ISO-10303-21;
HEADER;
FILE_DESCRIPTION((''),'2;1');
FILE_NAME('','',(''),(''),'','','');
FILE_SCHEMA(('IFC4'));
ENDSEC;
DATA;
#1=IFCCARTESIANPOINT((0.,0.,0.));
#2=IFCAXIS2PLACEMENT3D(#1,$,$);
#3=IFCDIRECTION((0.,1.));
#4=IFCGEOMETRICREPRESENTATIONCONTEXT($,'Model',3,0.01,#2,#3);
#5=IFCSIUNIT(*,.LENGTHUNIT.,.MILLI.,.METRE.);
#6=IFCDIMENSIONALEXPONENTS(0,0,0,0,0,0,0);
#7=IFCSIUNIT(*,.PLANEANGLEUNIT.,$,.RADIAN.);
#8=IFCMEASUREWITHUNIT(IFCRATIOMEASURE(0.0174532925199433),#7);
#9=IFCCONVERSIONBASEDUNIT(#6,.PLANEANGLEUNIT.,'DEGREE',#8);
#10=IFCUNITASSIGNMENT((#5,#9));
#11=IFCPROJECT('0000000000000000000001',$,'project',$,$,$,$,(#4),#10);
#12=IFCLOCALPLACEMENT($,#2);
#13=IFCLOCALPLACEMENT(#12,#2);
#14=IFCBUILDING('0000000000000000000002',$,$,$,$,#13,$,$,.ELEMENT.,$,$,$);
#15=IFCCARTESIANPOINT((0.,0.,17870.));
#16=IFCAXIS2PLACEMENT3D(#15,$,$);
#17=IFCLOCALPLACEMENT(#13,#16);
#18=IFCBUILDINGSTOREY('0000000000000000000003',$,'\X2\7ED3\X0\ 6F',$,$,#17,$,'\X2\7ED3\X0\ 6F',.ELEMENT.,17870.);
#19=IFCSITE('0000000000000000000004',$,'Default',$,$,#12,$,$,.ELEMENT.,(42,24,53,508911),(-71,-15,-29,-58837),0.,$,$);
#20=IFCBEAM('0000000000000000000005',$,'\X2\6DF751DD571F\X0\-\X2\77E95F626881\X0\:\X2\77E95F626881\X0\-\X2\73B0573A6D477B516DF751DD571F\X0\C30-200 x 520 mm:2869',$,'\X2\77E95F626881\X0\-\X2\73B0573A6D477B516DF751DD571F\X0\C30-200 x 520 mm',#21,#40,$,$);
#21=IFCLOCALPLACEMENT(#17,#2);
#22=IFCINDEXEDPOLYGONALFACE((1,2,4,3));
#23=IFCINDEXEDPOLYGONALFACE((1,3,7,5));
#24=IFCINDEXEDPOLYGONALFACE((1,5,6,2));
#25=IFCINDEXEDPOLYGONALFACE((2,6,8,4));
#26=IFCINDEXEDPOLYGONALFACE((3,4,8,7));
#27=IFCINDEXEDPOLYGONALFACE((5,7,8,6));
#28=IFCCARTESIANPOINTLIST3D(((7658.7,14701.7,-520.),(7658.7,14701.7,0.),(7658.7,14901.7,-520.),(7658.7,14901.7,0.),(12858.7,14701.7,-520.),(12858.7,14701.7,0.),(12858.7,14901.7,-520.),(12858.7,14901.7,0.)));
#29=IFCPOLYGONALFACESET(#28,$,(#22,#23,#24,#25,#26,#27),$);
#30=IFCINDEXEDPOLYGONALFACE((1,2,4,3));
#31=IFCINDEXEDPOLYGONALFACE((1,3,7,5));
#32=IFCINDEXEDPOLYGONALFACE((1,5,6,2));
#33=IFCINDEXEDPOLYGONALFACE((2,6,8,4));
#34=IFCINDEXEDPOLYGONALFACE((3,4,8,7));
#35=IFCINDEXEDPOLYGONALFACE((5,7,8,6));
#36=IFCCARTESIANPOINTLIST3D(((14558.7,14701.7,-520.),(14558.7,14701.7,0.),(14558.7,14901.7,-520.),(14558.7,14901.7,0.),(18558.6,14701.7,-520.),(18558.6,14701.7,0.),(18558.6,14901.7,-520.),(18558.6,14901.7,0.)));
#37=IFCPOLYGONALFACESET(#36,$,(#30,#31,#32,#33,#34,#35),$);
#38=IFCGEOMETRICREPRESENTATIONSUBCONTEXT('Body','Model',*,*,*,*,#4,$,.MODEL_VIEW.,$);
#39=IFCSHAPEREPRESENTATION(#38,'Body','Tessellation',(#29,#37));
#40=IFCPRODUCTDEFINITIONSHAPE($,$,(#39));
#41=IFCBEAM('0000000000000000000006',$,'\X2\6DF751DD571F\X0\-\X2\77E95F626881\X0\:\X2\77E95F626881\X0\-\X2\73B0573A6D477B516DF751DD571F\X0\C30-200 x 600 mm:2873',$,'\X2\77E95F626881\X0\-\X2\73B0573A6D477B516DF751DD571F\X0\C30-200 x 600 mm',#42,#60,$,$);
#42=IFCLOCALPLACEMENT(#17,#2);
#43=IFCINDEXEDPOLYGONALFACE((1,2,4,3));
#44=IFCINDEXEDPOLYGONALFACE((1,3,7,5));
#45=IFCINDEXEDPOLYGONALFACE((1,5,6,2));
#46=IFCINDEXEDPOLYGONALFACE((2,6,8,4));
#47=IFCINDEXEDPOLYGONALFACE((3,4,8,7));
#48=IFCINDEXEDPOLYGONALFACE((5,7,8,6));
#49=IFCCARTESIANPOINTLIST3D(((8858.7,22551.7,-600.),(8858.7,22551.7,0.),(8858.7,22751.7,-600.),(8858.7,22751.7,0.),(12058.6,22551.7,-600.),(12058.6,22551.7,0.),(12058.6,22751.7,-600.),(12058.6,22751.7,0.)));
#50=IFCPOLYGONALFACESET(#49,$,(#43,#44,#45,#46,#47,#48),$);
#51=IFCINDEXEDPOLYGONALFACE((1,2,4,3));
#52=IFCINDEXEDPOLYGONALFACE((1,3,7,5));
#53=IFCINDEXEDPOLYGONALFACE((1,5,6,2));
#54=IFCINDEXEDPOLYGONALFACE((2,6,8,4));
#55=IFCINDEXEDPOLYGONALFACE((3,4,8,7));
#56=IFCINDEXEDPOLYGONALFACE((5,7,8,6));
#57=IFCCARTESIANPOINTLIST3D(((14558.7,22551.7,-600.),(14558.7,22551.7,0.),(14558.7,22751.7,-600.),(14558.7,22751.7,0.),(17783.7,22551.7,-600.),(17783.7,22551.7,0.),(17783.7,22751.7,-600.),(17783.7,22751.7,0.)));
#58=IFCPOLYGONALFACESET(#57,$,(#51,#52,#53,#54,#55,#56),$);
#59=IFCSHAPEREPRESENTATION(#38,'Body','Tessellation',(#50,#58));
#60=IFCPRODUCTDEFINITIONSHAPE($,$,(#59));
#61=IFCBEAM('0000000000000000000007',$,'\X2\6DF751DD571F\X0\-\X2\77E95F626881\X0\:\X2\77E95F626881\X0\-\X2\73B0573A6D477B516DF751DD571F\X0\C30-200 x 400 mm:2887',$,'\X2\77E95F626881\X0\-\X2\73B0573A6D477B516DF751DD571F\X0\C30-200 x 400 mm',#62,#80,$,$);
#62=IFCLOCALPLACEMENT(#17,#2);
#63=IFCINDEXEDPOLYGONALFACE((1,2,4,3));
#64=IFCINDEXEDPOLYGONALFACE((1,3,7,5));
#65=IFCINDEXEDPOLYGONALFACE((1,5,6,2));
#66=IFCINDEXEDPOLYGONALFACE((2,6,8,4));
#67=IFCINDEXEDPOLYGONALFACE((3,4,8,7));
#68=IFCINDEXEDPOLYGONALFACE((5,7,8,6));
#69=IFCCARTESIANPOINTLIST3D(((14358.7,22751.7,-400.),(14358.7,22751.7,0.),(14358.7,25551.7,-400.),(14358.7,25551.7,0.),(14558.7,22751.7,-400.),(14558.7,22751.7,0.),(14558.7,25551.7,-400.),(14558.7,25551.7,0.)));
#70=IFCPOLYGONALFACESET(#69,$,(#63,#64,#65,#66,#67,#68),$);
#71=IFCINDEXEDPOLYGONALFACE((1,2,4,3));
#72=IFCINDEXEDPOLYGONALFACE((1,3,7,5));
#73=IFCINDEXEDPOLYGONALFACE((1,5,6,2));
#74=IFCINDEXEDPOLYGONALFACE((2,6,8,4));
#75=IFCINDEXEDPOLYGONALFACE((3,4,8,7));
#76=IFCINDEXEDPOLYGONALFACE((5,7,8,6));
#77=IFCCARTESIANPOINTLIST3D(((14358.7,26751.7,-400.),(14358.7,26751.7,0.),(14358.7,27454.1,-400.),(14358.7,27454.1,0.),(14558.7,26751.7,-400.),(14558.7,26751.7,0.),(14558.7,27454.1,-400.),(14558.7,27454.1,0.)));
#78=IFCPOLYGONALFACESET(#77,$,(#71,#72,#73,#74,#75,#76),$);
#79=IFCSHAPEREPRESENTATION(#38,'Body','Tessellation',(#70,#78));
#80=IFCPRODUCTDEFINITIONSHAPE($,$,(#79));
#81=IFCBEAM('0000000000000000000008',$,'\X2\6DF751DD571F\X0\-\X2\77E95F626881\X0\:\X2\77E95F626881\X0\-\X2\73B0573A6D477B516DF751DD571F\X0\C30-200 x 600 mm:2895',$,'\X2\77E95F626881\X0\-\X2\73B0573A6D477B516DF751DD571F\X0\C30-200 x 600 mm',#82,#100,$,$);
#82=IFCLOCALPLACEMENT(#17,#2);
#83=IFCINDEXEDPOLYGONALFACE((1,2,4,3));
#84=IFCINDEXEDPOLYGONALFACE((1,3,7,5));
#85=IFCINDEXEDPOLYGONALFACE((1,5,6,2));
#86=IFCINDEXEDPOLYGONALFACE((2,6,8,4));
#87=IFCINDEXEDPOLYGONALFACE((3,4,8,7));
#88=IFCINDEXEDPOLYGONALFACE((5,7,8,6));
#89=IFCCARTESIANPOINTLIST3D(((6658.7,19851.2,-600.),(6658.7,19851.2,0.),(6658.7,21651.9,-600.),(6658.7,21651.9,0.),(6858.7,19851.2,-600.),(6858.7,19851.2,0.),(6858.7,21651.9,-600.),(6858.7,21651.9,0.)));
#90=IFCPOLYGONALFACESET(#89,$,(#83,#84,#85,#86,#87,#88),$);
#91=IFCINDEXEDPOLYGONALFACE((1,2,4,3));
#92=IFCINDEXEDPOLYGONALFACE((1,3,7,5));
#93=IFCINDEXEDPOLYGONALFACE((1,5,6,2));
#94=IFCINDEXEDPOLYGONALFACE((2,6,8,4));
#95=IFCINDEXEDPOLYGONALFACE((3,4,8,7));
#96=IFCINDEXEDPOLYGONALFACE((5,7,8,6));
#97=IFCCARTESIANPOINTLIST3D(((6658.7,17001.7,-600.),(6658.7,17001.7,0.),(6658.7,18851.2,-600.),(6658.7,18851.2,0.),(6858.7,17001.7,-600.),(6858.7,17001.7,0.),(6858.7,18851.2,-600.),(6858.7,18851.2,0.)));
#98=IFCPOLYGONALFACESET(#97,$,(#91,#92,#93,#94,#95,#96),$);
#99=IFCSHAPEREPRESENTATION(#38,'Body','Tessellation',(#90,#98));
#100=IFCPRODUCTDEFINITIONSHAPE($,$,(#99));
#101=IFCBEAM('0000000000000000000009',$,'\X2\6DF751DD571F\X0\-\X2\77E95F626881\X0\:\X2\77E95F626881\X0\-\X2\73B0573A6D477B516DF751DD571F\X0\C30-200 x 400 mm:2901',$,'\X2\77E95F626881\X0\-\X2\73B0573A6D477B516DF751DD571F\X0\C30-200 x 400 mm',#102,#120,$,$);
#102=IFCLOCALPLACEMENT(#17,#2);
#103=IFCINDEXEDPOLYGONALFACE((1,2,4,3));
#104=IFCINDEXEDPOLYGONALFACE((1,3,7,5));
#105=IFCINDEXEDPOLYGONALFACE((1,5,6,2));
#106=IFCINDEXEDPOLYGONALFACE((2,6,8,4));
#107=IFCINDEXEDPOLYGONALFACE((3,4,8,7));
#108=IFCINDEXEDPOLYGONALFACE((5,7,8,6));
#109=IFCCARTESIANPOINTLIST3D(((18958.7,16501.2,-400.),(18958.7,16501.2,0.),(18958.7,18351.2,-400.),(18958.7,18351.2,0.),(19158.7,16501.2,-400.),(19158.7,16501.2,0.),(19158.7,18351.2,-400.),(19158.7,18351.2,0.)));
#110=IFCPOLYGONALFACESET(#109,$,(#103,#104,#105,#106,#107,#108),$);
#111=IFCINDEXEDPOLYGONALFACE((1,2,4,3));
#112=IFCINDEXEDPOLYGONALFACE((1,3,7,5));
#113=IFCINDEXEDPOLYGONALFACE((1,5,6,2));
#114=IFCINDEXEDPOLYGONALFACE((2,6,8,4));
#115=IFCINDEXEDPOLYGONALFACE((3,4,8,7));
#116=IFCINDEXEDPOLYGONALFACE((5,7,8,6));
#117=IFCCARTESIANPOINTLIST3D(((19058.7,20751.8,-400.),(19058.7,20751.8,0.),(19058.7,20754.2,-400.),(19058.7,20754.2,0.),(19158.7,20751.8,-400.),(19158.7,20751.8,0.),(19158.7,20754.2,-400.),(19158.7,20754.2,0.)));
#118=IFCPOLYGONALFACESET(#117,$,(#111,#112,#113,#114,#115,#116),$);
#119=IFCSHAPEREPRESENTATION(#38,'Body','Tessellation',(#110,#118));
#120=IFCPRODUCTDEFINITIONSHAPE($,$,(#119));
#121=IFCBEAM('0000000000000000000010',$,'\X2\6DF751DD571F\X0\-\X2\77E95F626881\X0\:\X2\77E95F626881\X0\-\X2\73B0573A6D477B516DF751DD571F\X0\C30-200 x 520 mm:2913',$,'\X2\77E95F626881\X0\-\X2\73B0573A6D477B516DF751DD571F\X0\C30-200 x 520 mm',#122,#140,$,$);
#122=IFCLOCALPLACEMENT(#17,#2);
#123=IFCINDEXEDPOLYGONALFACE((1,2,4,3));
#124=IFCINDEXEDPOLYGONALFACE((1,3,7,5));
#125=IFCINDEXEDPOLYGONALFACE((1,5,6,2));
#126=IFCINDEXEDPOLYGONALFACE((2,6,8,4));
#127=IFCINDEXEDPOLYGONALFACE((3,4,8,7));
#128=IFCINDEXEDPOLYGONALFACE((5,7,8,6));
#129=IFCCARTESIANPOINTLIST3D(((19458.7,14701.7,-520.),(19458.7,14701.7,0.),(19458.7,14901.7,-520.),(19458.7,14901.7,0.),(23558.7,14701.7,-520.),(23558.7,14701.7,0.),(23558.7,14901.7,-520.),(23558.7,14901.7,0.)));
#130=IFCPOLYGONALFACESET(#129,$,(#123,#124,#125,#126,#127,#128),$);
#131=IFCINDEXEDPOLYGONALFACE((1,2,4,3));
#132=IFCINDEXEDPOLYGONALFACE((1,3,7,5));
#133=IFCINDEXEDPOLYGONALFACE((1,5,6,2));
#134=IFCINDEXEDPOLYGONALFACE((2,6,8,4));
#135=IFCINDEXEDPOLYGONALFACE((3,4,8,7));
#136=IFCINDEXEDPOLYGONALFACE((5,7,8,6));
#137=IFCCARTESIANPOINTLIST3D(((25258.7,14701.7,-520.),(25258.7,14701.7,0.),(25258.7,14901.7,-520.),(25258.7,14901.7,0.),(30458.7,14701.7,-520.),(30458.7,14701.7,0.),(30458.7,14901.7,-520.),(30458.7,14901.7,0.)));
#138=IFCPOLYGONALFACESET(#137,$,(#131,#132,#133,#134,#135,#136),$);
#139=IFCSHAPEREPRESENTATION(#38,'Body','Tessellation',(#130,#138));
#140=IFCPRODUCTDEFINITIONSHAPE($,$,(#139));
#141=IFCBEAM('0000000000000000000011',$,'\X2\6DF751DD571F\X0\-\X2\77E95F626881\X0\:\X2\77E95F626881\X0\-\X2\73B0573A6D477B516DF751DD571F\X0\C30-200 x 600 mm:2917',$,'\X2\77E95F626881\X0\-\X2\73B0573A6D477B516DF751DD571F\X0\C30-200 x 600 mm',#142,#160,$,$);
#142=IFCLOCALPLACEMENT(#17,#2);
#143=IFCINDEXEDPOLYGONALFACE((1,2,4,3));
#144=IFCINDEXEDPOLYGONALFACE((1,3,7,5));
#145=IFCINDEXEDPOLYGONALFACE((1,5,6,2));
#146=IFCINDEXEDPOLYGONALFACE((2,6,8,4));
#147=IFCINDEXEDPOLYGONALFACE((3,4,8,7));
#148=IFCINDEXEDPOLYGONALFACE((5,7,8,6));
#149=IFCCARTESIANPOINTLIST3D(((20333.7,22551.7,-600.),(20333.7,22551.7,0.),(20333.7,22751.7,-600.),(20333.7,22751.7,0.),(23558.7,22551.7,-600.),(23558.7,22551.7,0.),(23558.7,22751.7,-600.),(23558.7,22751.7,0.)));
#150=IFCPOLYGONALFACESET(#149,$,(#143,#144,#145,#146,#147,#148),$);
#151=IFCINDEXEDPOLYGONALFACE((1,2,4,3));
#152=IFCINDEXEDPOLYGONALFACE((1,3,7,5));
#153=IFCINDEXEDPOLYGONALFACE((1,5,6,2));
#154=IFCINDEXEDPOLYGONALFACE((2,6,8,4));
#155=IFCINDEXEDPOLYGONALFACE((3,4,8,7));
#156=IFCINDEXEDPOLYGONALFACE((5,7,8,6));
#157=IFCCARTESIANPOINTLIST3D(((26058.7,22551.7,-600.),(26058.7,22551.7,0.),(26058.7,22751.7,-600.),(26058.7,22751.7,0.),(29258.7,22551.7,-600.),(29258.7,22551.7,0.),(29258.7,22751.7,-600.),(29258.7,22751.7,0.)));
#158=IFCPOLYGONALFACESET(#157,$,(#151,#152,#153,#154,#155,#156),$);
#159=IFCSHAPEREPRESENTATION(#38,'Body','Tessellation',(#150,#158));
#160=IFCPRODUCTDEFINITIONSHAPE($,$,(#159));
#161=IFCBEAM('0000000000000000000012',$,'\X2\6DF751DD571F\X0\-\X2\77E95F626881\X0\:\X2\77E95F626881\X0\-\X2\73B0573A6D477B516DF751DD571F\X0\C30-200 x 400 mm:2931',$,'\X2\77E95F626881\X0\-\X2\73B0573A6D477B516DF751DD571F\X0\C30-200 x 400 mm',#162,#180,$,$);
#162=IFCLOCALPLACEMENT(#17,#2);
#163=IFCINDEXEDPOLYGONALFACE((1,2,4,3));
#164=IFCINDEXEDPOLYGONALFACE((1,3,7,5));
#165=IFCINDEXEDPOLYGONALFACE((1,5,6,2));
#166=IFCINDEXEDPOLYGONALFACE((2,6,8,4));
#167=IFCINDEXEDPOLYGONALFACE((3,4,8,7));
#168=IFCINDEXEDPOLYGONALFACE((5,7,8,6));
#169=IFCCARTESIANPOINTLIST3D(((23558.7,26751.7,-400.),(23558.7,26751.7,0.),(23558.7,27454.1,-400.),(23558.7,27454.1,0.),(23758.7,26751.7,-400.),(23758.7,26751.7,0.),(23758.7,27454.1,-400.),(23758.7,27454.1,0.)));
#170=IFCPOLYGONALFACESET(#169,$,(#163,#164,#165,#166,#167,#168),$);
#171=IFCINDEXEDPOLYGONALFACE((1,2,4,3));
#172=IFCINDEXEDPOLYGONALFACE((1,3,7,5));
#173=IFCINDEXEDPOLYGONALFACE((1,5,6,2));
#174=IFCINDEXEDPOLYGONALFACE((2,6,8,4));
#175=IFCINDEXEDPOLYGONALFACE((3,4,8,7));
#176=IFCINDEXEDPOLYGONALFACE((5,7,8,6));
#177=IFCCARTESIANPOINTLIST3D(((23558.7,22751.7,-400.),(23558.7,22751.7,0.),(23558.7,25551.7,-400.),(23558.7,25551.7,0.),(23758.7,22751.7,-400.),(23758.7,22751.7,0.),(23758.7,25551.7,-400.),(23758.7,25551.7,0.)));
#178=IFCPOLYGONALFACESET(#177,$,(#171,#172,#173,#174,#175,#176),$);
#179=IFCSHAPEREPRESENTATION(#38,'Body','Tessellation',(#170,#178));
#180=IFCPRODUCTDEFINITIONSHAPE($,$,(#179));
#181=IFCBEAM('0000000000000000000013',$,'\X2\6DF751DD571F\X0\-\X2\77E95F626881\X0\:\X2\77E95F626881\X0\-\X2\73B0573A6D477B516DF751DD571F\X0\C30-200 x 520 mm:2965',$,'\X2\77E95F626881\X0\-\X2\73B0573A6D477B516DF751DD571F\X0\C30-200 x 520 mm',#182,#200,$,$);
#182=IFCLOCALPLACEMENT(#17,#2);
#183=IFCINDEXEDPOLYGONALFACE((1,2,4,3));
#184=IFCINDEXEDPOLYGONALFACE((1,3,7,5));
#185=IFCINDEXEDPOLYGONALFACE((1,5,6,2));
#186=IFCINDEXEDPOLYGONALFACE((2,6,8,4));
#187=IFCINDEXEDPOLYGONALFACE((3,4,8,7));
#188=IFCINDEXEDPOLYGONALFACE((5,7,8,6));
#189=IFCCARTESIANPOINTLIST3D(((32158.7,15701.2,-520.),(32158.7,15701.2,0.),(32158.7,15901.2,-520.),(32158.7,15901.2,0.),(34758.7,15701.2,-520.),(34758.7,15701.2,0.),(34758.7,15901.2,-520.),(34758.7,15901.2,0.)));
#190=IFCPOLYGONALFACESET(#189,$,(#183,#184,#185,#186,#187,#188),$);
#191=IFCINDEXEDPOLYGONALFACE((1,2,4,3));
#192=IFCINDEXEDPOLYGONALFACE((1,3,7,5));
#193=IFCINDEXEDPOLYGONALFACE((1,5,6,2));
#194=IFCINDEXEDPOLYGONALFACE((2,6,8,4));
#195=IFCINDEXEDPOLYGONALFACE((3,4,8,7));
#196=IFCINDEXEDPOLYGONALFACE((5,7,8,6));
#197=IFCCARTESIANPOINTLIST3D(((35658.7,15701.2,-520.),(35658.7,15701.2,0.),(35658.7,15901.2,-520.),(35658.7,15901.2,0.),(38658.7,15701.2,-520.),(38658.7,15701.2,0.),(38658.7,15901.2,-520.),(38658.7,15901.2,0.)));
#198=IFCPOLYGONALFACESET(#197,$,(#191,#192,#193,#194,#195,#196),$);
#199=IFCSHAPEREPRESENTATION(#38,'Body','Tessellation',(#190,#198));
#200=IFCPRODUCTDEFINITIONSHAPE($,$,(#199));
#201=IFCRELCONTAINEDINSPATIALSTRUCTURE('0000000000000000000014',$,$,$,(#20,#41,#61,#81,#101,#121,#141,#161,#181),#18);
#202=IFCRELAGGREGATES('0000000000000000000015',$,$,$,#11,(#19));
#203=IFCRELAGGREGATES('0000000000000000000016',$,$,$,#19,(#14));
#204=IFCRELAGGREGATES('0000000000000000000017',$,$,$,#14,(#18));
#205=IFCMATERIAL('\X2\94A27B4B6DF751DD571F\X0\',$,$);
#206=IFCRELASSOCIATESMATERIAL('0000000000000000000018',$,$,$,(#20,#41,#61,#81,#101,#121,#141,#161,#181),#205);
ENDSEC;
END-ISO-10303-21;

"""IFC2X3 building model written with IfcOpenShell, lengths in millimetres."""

from ifc_helpers import new_model, entity, si_unit, converted_unit, direction, frame, frame_2d, origin, origin_2d_with_axis, place, context, subcontext, project, spatial, rectangle, extrude, source, transform, mapped, material, element, save


model = new_model("IFC2X3")

# Units and contexts
model_context = context("Model", 3, precision=0.01, world=origin(), true_north=direction((0.0, 1.0)))
body_context = subcontext(model_context, "Body", "Model", "MODEL_VIEW")
ifc_project = project(units=[si_unit("LENGTHUNIT", "METRE", prefix="MILLI"), converted_unit("PLANEANGLEUNIT", "DEGREE", entity("IfcRatioMeasure", 0.0174532925199433), si_unit("PLANEANGLEUNIT", "RADIAN"), dimensions=[0, 0, 0, 0, 0, 0, 0])], contexts=[model_context])

# Site, building, storey
site_placement = place(None, origin())
site = spatial("IfcSite", under=ifc_project, at=site_placement, Name="Default", CompositionType="ELEMENT", RefLatitude=(42, 24, 53, 508911), RefLongitude=(-71, -15, -29, -58837), RefElevation=0.0)
building_placement = place(site_placement, origin())
building = spatial("IfcBuilding", under=site, at=building_placement, CompositionType="ELEMENT")
storey_placement = place(building_placement, frame((0.0, 0.0, 17870.0)))
storey = spatial("IfcBuildingStorey", under=building, at=storey_placement, Name="结 6F", LongName="结 6F", CompositionType="ELEMENT", Elevation=17870.0)

# Beams
ifc_material = material(Name="钢筋混凝土")
shared_shape_1 = source(origin(), body_context, "Body", "SweptSolid", [
    extrude(rectangle(XDim=5200.0, YDim=200.0, at=frame_2d((0.0, 0.0), x_axis=(1.0, 0.0))), frame((10258.7, 14801.7, 17350.0), z_axis=(0.0, 0.0, 1.0), x_axis=(-1.0, 0.0, 0.0)), (0.0, 0.0, 1.0), 520.0),
    extrude(rectangle(XDim=200.0, YDim=4000.0, at=frame_2d((0.0, 0.0), x_axis=(1.0, 0.0))), frame((16558.7, 14801.7, 17350.0), z_axis=(0.0, 0.0, 1.0), x_axis=(0.0, 1.0, 0.0)), (0.0, 0.0, 1.0), 520.0),
])
beam_1_placement = place(storey_placement, frame((0.0, 0.0, -17870.0)))
element("IfcBeam", 1, at=beam_1_placement, inside=storey, material=ifc_material, Name="混凝土-矩形梁:矩形梁-现场浇筑混凝土C30-200 x 520 mm:2869", ObjectType="矩形梁-现场浇筑混凝土C30-200 x 520 mm", context=body_context, shape_type="MappedRepresentation", body=[
    mapped(shared_shape_1, transform((0.0, 0.0, 0.0), scale=1.0)),
])
shared_shape_2 = source(origin(), body_context, "Body", "SweptSolid", [
    extrude(rectangle(XDim=3200.0, YDim=200.0, at=frame_2d((0.0, 0.0), x_axis=(1.0, 0.0))), frame((10458.7, 22651.7, 17270.0), z_axis=(0.0, 0.0, 1.0), x_axis=(-1.0, 0.0, 0.0)), (0.0, 0.0, 1.0), 600.0),
    extrude(rectangle(XDim=3225.0, YDim=200.0, at=origin_2d_with_axis()), frame((16171.2, 22651.7, 17270.0), z_axis=(0.0, 0.0, 1.0), x_axis=(-1.0, 0.0, 0.0)), (0.0, 0.0, 1.0), 600.0),
])
beam_2_placement = place(storey_placement, frame((0.0, 0.0, -17870.0)))
element("IfcBeam", 2, at=beam_2_placement, inside=storey, material=ifc_material, Name="混凝土-矩形梁:矩形梁-现场浇筑混凝土C30-200 x 600 mm:2873", ObjectType="矩形梁-现场浇筑混凝土C30-200 x 600 mm", context=body_context, shape_type="MappedRepresentation", body=[
    mapped(shared_shape_2, transform((0.0, 0.0, 0.0), scale=1.0)),
])
shared_shape_3 = source(origin(), body_context, "Body", "SweptSolid", [
    extrude(rectangle(XDim=2800.0, YDim=200.0, at=frame_2d((0.0, 0.0), x_axis=(1.0, 0.0))), frame((14458.7, 24151.7, 17470.0), z_axis=(0.0, 0.0, 1.0), x_axis=(0.0, 1.0, 0.0)), (0.0, 0.0, 1.0), 400.0),
    extrude(rectangle(XDim=702.4, YDim=200.0, at=frame_2d((0.0, 0.0), x_axis=(1.0, 0.0))), frame((14458.7, 27102.9, 17470.0), z_axis=(0.0, 0.0, 1.0), x_axis=(0.0, -1.0, 0.0)), (0.0, 0.0, 1.0), 400.0),
])
beam_3_placement = place(storey_placement, frame((0.0, 0.0, -17870.0)))
element("IfcBeam", 3, at=beam_3_placement, inside=storey, material=ifc_material, Name="混凝土-矩形梁:矩形梁-现场浇筑混凝土C30-200 x 400 mm:2887", ObjectType="矩形梁-现场浇筑混凝土C30-200 x 400 mm", context=body_context, shape_type="MappedRepresentation", body=[
    mapped(shared_shape_3, transform((0.0, 0.0, 0.0), scale=1.0)),
])
shared_shape_4 = source(origin(), body_context, "Body", "SweptSolid", [
    extrude(rectangle(XDim=1800.7, YDim=200.0, at=frame_2d((0.0, 0.0), x_axis=(1.0, 0.0))), frame((6758.7, 20751.6, 17270.0), z_axis=(0.0, 0.0, 1.0), x_axis=(0.0, -1.0, 0.0)), (0.0, 0.0, 1.0), 600.0),
    extrude(rectangle(XDim=1849.5, YDim=200.0, at=frame_2d((0.0, 0.0), x_axis=(1.0, 0.0))), frame((6758.7, 17926.5, 17270.0), z_axis=(0.0, 0.0, 1.0), x_axis=(0.0, 1.0, 0.0)), (0.0, 0.0, 1.0), 600.0),
])
beam_4_placement = place(storey_placement, frame((0.0, 0.0, -17870.0)))
element("IfcBeam", 4, at=beam_4_placement, inside=storey, material=ifc_material, Name="混凝土-矩形梁:矩形梁-现场浇筑混凝土C30-200 x 600 mm:2895", ObjectType="矩形梁-现场浇筑混凝土C30-200 x 600 mm", context=body_context, shape_type="MappedRepresentation", body=[
    mapped(shared_shape_4, transform((0.0, 0.0, 0.0), scale=1.0)),
])
shared_shape_5 = source(origin(), body_context, "Body", "SweptSolid", [
    extrude(rectangle(XDim=1850.0, YDim=200.0, at=frame_2d((0.0, 0.0), x_axis=(1.0, 0.0))), frame((19058.7, 17426.2, 17470.0), z_axis=(0.0, 0.0, 1.0), x_axis=(0.0, -1.0, 0.0)), (0.0, 0.0, 1.0), 400.0),
    extrude(rectangle(XDim=100.0, YDim=2.4, at=origin_2d_with_axis()), frame((19108.7, 20753.0, 17470.0), z_axis=(0.0, 0.0, 1.0), x_axis=(-1.0, 0.0, 0.0)), (0.0, 0.0, 1.0), 400.0),
])
beam_5_placement = place(storey_placement, frame((0.0, 0.0, -17870.0)))
element("IfcBeam", 5, at=beam_5_placement, inside=storey, material=ifc_material, Name="混凝土-矩形梁:矩形梁-现场浇筑混凝土C30-200 x 400 mm:2901", ObjectType="矩形梁-现场浇筑混凝土C30-200 x 400 mm", context=body_context, shape_type="MappedRepresentation", body=[
    mapped(shared_shape_5, transform((0.0, 0.0, 0.0), scale=1.0)),
])
shared_shape_6 = source(origin(), body_context, "Body", "SweptSolid", [
    extrude(rectangle(XDim=4100.0, YDim=200.0, at=frame_2d((0.0, 0.0), x_axis=(1.0, 0.0))), frame((21508.7, 14801.7, 17350.0)), (0.0, 0.0, 1.0), 520.0),
    extrude(rectangle(XDim=5200.0, YDim=200.0, at=frame_2d((0.0, 0.0), x_axis=(1.0, 0.0))), frame((27858.7, 14801.7, 17350.0)), (0.0, 0.0, 1.0), 520.0),
])
beam_6_placement = place(storey_placement, frame((0.0, 0.0, -17870.0)))
element("IfcBeam", 6, at=beam_6_placement, inside=storey, material=ifc_material, Name="混凝土-矩形梁:矩形梁-现场浇筑混凝土C30-200 x 520 mm:2913", ObjectType="矩形梁-现场浇筑混凝土C30-200 x 520 mm", context=body_context, shape_type="MappedRepresentation", body=[
    mapped(shared_shape_6, transform((0.0, 0.0, 0.0), scale=1.0)),
])
shared_shape_7 = source(origin(), body_context, "Body", "SweptSolid", [
    extrude(rectangle(XDim=3225.0, YDim=200.0, at=origin_2d_with_axis()), frame((21946.2, 22651.7, 17270.0)), (0.0, 0.0, 1.0), 600.0),
    extrude(rectangle(XDim=3200.0, YDim=200.0, at=frame_2d((0.0, 0.0), x_axis=(1.0, 0.0))), frame((27658.7, 22651.7, 17270.0)), (0.0, 0.0, 1.0), 600.0),
])
beam_7_placement = place(storey_placement, frame((0.0, 0.0, -17870.0)))
element("IfcBeam", 7, at=beam_7_placement, inside=storey, material=ifc_material, Name="混凝土-矩形梁:矩形梁-现场浇筑混凝土C30-200 x 600 mm:2917", ObjectType="矩形梁-现场浇筑混凝土C30-200 x 600 mm", context=body_context, shape_type="MappedRepresentation", body=[
    mapped(shared_shape_7, transform((0.0, 0.0, 0.0), scale=1.0)),
])
shared_shape_8 = source(origin(), body_context, "Body", "SweptSolid", [
    extrude(rectangle(XDim=702.4, YDim=200.0, at=origin_2d_with_axis()), frame((23658.7, 27102.9, 17470.0), z_axis=(0.0, 0.0, 1.0), x_axis=(0.0, -1.0, 0.0)), (0.0, 0.0, 1.0), 400.0),
    extrude(rectangle(XDim=2800.0, YDim=200.0, at=frame_2d((0.0, 0.0), x_axis=(1.0, 0.0))), frame((23658.7, 24151.7, 17470.0), z_axis=(0.0, 0.0, 1.0), x_axis=(0.0, 1.0, 0.0)), (0.0, 0.0, 1.0), 400.0),
])
beam_8_placement = place(storey_placement, frame((0.0, 0.0, -17870.0)))
element("IfcBeam", 8, at=beam_8_placement, inside=storey, material=ifc_material, Name="混凝土-矩形梁:矩形梁-现场浇筑混凝土C30-200 x 400 mm:2931", ObjectType="矩形梁-现场浇筑混凝土C30-200 x 400 mm", context=body_context, shape_type="MappedRepresentation", body=[
    mapped(shared_shape_8, transform((0.0, 0.0, 0.0), scale=1.0)),
])
shared_shape_9 = source(origin(), body_context, "Body", "SweptSolid", [
    extrude(rectangle(XDim=2600.0, YDim=200.0, at=frame_2d((0.0, 0.0), x_axis=(1.0, 0.0))), frame((33458.7, 15801.2, 17350.0), z_axis=(0.0, 0.0, 1.0), x_axis=(-1.0, 0.0, 0.0)), (0.0, 0.0, 1.0), 520.0),
    extrude(rectangle(XDim=3000.0, YDim=200.0, at=frame_2d((0.0, 0.0), x_axis=(1.0, 0.0))), frame((37158.7, 15801.2, 17350.0), z_axis=(0.0, 0.0, 1.0), x_axis=(-1.0, 0.0, 0.0)), (0.0, 0.0, 1.0), 520.0),
])
beam_9_placement = place(storey_placement, frame((0.0, 0.0, -17870.0)))
element("IfcBeam", 9, at=beam_9_placement, inside=storey, material=ifc_material, Name="混凝土-矩形梁:矩形梁-现场浇筑混凝土C30-200 x 520 mm:2965", ObjectType="矩形梁-现场浇筑混凝土C30-200 x 520 mm", context=body_context, shape_type="MappedRepresentation", body=[
    mapped(shared_shape_9, transform((0.0, 0.0, 0.0), scale=1.0)),
])

save(model, "model.ifc")
